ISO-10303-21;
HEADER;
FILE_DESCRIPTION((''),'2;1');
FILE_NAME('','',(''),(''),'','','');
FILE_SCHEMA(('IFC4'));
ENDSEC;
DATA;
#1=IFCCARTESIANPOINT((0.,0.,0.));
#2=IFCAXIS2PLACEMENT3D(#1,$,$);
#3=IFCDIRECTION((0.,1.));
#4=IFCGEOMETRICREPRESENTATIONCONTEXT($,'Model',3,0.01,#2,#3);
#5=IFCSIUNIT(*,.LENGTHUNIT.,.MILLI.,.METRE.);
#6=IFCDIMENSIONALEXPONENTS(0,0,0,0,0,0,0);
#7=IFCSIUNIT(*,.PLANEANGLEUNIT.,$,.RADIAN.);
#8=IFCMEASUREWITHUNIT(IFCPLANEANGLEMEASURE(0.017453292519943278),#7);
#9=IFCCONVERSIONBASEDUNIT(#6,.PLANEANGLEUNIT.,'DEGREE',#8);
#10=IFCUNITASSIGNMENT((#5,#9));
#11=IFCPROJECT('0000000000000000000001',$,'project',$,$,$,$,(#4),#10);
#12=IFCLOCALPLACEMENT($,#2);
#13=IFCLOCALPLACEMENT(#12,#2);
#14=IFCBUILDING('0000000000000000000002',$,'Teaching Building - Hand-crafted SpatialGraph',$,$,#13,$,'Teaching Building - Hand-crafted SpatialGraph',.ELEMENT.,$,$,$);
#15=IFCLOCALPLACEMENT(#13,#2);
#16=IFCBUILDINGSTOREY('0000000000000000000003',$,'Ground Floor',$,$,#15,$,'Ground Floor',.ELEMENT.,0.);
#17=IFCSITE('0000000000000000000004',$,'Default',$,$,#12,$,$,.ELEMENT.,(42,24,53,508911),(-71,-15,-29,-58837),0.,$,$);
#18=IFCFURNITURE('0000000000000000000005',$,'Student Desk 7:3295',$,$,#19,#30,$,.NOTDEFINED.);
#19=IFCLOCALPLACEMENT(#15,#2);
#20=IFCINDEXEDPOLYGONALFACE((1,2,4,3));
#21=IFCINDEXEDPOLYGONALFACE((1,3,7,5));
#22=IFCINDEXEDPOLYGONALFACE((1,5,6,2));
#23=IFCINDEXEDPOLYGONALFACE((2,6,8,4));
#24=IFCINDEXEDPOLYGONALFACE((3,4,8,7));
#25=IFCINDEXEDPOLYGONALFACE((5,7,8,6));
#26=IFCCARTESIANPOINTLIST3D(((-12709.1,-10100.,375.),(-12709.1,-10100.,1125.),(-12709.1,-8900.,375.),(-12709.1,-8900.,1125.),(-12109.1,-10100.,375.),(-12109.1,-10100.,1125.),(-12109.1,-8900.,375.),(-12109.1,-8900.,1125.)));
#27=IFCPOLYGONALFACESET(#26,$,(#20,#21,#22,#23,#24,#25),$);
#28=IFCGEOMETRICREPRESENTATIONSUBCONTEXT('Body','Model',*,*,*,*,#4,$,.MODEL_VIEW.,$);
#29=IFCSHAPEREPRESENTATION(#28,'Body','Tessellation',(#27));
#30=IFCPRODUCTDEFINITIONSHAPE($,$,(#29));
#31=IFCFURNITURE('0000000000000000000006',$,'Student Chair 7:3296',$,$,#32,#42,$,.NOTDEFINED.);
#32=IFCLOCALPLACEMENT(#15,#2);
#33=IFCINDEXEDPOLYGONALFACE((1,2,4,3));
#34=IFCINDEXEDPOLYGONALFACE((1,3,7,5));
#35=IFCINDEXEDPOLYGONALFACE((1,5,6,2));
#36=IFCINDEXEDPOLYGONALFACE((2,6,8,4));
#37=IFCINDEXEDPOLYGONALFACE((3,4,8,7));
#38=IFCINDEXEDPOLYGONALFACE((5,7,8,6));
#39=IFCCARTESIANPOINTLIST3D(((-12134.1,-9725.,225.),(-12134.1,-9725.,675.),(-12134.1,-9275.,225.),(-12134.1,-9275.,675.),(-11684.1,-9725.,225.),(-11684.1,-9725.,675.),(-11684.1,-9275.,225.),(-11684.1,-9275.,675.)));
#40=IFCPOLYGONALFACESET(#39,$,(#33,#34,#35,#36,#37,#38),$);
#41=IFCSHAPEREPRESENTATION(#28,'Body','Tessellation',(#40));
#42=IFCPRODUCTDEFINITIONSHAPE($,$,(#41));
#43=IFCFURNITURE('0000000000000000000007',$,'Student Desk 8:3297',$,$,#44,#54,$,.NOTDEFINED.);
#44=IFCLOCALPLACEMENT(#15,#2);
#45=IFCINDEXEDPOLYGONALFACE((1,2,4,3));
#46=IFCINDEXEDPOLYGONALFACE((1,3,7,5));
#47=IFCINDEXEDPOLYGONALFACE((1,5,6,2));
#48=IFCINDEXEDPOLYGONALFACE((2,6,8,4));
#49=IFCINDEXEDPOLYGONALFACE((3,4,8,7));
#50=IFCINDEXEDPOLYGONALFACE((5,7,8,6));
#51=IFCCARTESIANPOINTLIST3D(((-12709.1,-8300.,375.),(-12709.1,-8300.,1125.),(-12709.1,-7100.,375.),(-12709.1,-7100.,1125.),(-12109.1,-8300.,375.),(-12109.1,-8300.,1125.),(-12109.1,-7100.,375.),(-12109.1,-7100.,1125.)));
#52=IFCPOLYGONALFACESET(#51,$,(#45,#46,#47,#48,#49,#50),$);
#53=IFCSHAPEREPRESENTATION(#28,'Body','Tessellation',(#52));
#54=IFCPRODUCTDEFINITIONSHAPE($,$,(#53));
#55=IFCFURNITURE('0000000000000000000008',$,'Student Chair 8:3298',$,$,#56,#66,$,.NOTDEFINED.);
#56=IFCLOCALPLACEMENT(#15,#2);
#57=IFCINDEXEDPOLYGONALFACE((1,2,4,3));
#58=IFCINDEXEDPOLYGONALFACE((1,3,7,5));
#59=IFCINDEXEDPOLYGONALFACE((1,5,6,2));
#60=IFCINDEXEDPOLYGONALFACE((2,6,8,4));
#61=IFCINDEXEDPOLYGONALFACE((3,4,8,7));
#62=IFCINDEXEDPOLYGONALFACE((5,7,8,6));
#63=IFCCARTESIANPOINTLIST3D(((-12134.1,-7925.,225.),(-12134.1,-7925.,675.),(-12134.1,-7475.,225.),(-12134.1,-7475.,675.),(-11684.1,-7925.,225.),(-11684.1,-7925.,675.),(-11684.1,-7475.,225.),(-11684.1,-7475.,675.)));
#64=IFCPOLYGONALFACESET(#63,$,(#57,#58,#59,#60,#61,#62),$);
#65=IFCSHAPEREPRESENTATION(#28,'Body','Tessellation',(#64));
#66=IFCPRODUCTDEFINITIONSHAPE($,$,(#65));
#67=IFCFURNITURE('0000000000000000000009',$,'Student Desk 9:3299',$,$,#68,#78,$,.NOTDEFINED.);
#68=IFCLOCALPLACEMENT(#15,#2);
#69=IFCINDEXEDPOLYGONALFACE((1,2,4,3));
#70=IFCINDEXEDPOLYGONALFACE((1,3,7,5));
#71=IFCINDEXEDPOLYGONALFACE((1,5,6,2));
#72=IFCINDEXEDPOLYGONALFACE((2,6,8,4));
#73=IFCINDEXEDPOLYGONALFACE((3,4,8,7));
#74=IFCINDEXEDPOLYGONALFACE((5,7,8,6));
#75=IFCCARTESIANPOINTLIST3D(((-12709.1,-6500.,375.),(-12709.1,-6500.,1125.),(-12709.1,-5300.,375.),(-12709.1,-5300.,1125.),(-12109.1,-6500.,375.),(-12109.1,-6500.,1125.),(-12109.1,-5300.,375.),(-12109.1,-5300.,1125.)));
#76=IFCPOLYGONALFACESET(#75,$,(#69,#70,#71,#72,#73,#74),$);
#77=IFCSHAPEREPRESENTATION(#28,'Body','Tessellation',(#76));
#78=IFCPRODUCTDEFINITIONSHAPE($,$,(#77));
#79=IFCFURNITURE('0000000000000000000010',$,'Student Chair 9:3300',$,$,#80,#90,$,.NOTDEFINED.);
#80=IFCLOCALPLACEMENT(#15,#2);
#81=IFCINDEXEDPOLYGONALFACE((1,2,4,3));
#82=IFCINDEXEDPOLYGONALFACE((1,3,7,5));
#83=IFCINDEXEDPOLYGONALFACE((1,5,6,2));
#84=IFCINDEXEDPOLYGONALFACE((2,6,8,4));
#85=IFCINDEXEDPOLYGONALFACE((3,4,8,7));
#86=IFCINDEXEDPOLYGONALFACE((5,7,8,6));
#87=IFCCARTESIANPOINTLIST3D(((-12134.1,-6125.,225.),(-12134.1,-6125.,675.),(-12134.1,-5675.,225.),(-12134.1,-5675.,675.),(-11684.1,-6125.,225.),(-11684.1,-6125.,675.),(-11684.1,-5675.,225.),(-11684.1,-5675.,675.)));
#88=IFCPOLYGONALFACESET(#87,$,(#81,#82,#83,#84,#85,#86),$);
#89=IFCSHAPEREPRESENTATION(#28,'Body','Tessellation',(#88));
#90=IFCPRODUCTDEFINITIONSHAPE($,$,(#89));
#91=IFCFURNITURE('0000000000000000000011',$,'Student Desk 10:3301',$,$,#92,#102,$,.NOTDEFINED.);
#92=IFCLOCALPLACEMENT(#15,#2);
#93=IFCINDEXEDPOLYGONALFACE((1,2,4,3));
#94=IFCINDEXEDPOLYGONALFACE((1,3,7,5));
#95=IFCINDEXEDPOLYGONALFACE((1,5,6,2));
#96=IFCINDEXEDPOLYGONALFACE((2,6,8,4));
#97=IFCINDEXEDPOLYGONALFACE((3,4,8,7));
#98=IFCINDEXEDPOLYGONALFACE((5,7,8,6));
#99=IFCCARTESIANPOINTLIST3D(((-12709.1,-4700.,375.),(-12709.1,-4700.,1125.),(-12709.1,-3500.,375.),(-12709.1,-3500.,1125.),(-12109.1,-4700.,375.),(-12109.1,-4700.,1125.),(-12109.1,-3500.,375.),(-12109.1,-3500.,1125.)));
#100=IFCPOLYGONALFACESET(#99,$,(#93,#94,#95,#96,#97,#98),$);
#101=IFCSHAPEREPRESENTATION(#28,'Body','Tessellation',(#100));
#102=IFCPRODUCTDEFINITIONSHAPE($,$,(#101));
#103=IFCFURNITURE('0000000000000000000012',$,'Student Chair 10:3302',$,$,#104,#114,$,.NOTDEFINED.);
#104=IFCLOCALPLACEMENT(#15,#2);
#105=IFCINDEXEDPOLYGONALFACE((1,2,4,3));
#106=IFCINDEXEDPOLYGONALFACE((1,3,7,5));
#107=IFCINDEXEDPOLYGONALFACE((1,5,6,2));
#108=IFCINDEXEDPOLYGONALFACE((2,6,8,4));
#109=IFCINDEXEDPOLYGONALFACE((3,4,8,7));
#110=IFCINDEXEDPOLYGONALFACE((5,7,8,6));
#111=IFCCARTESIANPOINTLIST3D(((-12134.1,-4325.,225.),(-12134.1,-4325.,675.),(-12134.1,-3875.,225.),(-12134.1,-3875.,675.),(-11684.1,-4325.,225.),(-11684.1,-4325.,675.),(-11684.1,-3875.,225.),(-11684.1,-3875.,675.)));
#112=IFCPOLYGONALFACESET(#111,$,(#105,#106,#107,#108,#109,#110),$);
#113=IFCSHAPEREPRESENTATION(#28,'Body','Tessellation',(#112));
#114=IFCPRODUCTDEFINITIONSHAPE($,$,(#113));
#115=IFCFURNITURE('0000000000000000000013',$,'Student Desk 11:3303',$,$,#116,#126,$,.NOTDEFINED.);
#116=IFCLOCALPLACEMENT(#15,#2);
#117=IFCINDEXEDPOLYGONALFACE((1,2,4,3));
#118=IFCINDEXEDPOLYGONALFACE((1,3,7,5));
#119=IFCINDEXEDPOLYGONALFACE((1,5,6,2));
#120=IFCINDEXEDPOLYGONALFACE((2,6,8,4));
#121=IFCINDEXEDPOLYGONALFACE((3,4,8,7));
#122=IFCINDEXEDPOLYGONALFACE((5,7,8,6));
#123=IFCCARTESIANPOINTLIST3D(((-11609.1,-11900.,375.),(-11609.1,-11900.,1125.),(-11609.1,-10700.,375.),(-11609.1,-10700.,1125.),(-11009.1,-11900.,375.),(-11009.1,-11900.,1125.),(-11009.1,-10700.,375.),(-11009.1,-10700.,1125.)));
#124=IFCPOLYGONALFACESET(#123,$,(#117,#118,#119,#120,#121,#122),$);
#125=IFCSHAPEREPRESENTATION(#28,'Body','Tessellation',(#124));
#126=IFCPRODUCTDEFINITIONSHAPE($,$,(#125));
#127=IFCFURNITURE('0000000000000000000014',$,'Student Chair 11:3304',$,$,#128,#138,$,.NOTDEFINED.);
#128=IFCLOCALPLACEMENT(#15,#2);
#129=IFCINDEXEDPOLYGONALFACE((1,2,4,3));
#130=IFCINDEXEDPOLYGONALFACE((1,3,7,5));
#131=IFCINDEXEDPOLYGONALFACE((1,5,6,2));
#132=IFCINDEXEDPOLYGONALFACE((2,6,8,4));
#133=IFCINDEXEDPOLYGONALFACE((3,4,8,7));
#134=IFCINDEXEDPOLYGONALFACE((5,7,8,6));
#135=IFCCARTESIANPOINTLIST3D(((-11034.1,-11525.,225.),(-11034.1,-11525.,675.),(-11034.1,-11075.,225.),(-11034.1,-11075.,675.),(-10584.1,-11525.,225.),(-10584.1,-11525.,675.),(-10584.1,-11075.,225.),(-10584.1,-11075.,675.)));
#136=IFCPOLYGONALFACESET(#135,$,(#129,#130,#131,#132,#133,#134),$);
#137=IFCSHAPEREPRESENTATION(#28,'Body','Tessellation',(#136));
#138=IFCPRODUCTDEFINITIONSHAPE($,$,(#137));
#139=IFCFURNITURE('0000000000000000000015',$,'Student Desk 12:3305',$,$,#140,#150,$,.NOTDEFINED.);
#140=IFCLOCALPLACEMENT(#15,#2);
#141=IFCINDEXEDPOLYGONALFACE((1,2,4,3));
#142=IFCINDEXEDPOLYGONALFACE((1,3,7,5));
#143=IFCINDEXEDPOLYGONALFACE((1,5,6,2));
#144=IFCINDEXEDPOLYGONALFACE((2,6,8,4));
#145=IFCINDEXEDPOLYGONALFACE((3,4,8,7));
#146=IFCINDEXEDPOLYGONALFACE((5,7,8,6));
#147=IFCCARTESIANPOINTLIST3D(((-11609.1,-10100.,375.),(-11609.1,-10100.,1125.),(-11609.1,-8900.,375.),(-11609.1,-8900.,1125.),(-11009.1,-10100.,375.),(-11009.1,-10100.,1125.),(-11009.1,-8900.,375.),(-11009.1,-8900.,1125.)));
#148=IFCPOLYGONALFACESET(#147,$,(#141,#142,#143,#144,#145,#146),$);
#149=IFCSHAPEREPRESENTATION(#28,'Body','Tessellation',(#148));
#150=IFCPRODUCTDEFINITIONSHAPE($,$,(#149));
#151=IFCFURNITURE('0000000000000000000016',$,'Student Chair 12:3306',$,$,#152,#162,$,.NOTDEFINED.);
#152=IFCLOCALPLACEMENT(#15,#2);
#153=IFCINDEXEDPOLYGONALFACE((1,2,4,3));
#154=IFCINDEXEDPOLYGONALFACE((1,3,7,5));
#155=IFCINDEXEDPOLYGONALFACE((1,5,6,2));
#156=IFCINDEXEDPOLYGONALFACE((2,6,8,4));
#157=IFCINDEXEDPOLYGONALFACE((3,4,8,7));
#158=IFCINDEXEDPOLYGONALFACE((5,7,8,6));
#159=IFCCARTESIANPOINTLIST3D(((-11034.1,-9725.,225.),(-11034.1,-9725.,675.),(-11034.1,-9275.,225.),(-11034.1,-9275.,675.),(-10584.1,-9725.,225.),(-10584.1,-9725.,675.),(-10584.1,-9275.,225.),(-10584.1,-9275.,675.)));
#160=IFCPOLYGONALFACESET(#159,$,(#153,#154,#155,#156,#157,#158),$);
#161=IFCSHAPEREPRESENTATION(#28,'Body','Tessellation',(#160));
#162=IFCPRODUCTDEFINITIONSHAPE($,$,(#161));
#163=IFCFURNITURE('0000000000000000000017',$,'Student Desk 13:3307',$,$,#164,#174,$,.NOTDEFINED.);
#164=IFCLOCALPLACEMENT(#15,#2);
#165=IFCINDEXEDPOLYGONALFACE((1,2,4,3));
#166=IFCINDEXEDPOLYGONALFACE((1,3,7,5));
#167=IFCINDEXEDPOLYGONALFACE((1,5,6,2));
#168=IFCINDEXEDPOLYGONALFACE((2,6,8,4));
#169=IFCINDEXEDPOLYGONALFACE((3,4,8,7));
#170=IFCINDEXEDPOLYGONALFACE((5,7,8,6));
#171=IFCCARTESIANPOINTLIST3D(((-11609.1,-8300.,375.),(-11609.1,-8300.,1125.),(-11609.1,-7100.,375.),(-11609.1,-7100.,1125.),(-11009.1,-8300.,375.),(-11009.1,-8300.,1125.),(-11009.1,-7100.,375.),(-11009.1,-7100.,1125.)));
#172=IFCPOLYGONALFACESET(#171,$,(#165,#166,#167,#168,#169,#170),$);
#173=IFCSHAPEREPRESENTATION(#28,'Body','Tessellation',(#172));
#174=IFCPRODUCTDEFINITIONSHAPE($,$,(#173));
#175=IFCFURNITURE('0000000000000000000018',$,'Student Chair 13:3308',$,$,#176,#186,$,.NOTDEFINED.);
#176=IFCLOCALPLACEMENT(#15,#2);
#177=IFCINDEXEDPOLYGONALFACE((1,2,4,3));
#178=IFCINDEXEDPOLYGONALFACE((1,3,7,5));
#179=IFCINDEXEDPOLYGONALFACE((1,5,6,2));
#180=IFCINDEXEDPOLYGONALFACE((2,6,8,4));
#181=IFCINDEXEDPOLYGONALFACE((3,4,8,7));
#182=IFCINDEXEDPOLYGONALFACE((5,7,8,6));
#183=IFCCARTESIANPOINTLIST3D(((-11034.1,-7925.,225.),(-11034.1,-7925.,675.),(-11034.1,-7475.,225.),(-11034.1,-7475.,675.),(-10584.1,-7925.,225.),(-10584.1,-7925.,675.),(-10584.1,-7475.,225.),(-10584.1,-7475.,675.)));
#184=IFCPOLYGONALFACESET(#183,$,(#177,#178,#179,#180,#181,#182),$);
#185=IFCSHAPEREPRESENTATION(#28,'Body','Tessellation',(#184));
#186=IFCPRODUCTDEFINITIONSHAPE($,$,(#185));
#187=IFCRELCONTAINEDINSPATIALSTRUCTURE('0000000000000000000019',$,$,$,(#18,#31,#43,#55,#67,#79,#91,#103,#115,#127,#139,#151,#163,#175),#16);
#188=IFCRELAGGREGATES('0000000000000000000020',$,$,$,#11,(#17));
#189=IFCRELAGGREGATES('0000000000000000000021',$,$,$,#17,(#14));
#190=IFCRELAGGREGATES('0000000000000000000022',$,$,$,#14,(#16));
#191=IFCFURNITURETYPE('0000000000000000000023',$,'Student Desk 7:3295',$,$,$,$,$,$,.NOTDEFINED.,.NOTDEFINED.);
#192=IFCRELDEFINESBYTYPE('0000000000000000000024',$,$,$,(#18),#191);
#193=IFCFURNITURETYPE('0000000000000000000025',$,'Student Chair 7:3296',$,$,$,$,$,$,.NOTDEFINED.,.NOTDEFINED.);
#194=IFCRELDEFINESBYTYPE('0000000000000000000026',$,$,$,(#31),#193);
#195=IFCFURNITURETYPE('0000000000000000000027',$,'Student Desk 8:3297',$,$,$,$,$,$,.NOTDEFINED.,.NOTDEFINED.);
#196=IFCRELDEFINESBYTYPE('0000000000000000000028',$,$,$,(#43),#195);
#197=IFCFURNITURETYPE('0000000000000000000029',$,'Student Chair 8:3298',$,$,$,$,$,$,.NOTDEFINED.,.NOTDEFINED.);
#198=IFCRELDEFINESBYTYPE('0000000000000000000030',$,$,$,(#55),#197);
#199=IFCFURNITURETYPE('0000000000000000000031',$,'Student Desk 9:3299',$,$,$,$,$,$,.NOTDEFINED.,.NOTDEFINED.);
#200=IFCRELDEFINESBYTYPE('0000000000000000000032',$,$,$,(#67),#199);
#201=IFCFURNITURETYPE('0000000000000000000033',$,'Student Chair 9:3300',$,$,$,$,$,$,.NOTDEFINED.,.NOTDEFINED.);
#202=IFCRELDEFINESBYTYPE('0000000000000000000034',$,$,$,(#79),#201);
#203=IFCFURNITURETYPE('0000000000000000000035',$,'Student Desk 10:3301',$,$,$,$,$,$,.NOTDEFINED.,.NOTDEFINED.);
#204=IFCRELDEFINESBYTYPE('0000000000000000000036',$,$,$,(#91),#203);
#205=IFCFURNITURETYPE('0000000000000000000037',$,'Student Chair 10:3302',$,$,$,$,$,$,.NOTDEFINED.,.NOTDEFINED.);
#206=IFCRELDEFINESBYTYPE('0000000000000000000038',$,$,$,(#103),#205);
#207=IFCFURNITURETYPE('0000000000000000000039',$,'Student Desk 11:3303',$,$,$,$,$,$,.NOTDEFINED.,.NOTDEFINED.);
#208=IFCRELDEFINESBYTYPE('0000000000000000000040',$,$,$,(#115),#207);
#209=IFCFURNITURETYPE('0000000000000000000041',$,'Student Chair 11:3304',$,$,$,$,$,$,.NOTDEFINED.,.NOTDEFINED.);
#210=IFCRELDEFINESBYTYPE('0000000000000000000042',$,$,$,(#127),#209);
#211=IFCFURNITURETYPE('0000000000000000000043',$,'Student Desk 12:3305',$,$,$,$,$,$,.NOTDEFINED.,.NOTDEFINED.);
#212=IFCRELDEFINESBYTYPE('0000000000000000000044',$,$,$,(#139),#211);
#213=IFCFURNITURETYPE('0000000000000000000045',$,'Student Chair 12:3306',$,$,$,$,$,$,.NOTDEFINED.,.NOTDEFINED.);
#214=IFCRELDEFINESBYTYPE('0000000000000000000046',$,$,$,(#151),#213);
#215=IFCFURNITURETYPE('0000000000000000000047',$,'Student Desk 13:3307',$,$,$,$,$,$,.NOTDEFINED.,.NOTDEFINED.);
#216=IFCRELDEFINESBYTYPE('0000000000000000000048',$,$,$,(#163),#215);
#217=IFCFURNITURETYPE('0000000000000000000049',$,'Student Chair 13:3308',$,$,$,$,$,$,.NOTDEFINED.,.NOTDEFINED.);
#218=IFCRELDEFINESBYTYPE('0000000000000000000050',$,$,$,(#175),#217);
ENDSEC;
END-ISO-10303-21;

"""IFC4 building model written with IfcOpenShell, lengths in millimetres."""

from ifc_helpers import new_model, entity, si_unit, converted_unit, direction, frame, frame_2d, origin, origin_2d_with_axis, place, context, subcontext, project, spatial, rectangle, extrude, type_object, element, save


model = new_model("IFC4")

# Units and contexts
model_context = context("Model", 3, precision=0.01, world=origin(), true_north=direction((0.0, 1.0)))
body_context = subcontext(model_context, "Body", "Model", "MODEL_VIEW")
ifc_project = project(units=[si_unit("LENGTHUNIT", "METRE", prefix="MILLI"), converted_unit("PLANEANGLEUNIT", "DEGREE", entity("IfcPlaneAngleMeasure", 0.017453292519943278), si_unit("PLANEANGLEUNIT", "RADIAN"), dimensions=[0, 0, 0, 0, 0, 0, 0])], contexts=[model_context])

# Site, building, storey
site_placement = place(None, origin())
site = spatial("IfcSite", under=ifc_project, at=site_placement, Name="Default", CompositionType="ELEMENT", RefLatitude=(42, 24, 53, 508911), RefLongitude=(-71, -15, -29, -58837), RefElevation=0.0)
building_placement = place(site_placement, origin())
building = spatial("IfcBuilding", under=site, at=building_placement, Name="Teaching Building - Hand-crafted SpatialGraph", LongName="Teaching Building - Hand-crafted SpatialGraph", CompositionType="ELEMENT")
storey_placement = place(building_placement, origin())
storey = spatial("IfcBuildingStorey", under=building, at=storey_placement, Name="Ground Floor", LongName="Ground Floor", CompositionType="ELEMENT", Elevation=0.0)

# Furniture
furniture_type_1 = type_object("IfcFurnitureType", Name="Student Desk 7:3295", PredefinedType="NOTDEFINED")
furniture_1_placement = place(storey_placement, origin())
element("IfcFurniture", 1, at=furniture_1_placement, inside=storey, type_object=furniture_type_1, Name="Student Desk 7:3295", PredefinedType="NOTDEFINED", context=body_context, shape_type="SweptSolid", body=[
    extrude(rectangle(XDim=1200.0, YDim=600.0, at=origin_2d_with_axis()), frame((-12409.1, -9500.0, 375.0), z_axis=(0.0, 0.0, 1.0), x_axis=(0.0, 1.0, 0.0)), (0.0, 0.0, 1.0), 750.0),
])
furniture_type_2 = type_object("IfcFurnitureType", Name="Student Chair 7:3296", PredefinedType="NOTDEFINED")
furniture_2_placement = place(storey_placement, origin())
element("IfcFurniture", 2, at=furniture_2_placement, inside=storey, type_object=furniture_type_2, Name="Student Chair 7:3296", PredefinedType="NOTDEFINED", context=body_context, shape_type="SweptSolid", body=[
    extrude(rectangle(XDim=450.0, YDim=450.0, at=origin_2d_with_axis()), frame((-11909.1, -9500.0, 225.0)), (0.0, 0.0, 1.0), 450.0),
])
furniture_type_3 = type_object("IfcFurnitureType", Name="Student Desk 8:3297", PredefinedType="NOTDEFINED")
furniture_3_placement = place(storey_placement, origin())
element("IfcFurniture", 3, at=furniture_3_placement, inside=storey, type_object=furniture_type_3, Name="Student Desk 8:3297", PredefinedType="NOTDEFINED", context=body_context, shape_type="SweptSolid", body=[
    extrude(rectangle(XDim=1200.0, YDim=600.0, at=origin_2d_with_axis()), frame((-12409.1, -7700.0, 375.0), z_axis=(0.0, 0.0, 1.0), x_axis=(0.0, 1.0, 0.0)), (0.0, 0.0, 1.0), 750.0),
])
furniture_type_4 = type_object("IfcFurnitureType", Name="Student Chair 8:3298", PredefinedType="NOTDEFINED")
furniture_4_placement = place(storey_placement, origin())
element("IfcFurniture", 4, at=furniture_4_placement, inside=storey, type_object=furniture_type_4, Name="Student Chair 8:3298", PredefinedType="NOTDEFINED", context=body_context, shape_type="SweptSolid", body=[
    extrude(rectangle(XDim=450.0, YDim=450.0, at=frame_2d((0.0, 0.0), x_axis=(1.0, 0.0))), frame((-11909.1, -7700.0, 225.0)), (0.0, 0.0, 1.0), 450.0),
])
furniture_type_5 = type_object("IfcFurnitureType", Name="Student Desk 9:3299", PredefinedType="NOTDEFINED")
furniture_5_placement = place(storey_placement, origin())
element("IfcFurniture", 5, at=furniture_5_placement, inside=storey, type_object=furniture_type_5, Name="Student Desk 9:3299", PredefinedType="NOTDEFINED", context=body_context, shape_type="SweptSolid", body=[
    extrude(rectangle(XDim=1200.0, YDim=600.0, at=origin_2d_with_axis()), frame((-12409.1, -5900.0, 375.0), z_axis=(0.0, 0.0, 1.0), x_axis=(0.0, 1.0, 0.0)), (0.0, 0.0, 1.0), 750.0),
])
furniture_type_6 = type_object("IfcFurnitureType", Name="Student Chair 9:3300", PredefinedType="NOTDEFINED")
furniture_6_placement = place(storey_placement, origin())
element("IfcFurniture", 6, at=furniture_6_placement, inside=storey, type_object=furniture_type_6, Name="Student Chair 9:3300", PredefinedType="NOTDEFINED", context=body_context, shape_type="SweptSolid", body=[
    extrude(rectangle(XDim=450.0, YDim=450.0, at=origin_2d_with_axis()), frame((-11909.1, -5900.0, 225.0)), (0.0, 0.0, 1.0), 450.0),
])
furniture_type_7 = type_object("IfcFurnitureType", Name="Student Desk 10:3301", PredefinedType="NOTDEFINED")
furniture_7_placement = place(storey_placement, origin())
element("IfcFurniture", 7, at=furniture_7_placement, inside=storey, type_object=furniture_type_7, Name="Student Desk 10:3301", PredefinedType="NOTDEFINED", context=body_context, shape_type="SweptSolid", body=[
    extrude(rectangle(XDim=1200.0, YDim=600.0, at=origin_2d_with_axis()), frame((-12409.1, -4100.0, 375.0), z_axis=(0.0, 0.0, 1.0), x_axis=(0.0, 1.0, 0.0)), (0.0, 0.0, 1.0), 750.0),
])
furniture_type_8 = type_object("IfcFurnitureType", Name="Student Chair 10:3302", PredefinedType="NOTDEFINED")
furniture_8_placement = place(storey_placement, origin())
element("IfcFurniture", 8, at=furniture_8_placement, inside=storey, type_object=furniture_type_8, Name="Student Chair 10:3302", PredefinedType="NOTDEFINED", context=body_context, shape_type="SweptSolid", body=[
    extrude(rectangle(XDim=450.0, YDim=450.0, at=origin_2d_with_axis()), frame((-11909.1, -4100.0, 225.0)), (0.0, 0.0, 1.0), 450.0),
])
furniture_type_9 = type_object("IfcFurnitureType", Name="Student Desk 11:3303", PredefinedType="NOTDEFINED")
furniture_9_placement = place(storey_placement, origin())
element("IfcFurniture", 9, at=furniture_9_placement, inside=storey, type_object=furniture_type_9, Name="Student Desk 11:3303", PredefinedType="NOTDEFINED", context=body_context, shape_type="SweptSolid", body=[
    extrude(rectangle(XDim=1200.0, YDim=600.0, at=origin_2d_with_axis()), frame((-11309.1, -11300.0, 375.0), z_axis=(0.0, 0.0, 1.0), x_axis=(0.0, 1.0, 0.0)), (0.0, 0.0, 1.0), 750.0),
])
furniture_type_10 = type_object("IfcFurnitureType", Name="Student Chair 11:3304", PredefinedType="NOTDEFINED")
furniture_10_placement = place(storey_placement, origin())
element("IfcFurniture", 10, at=furniture_10_placement, inside=storey, type_object=furniture_type_10, Name="Student Chair 11:3304", PredefinedType="NOTDEFINED", context=body_context, shape_type="SweptSolid", body=[
    extrude(rectangle(XDim=450.0, YDim=450.0, at=origin_2d_with_axis()), frame((-10809.1, -11300.0, 225.0)), (0.0, 0.0, 1.0), 450.0),
])
furniture_type_11 = type_object("IfcFurnitureType", Name="Student Desk 12:3305", PredefinedType="NOTDEFINED")
furniture_11_placement = place(storey_placement, origin())
element("IfcFurniture", 11, at=furniture_11_placement, inside=storey, type_object=furniture_type_11, Name="Student Desk 12:3305", PredefinedType="NOTDEFINED", context=body_context, shape_type="SweptSolid", body=[
    extrude(rectangle(XDim=1200.0, YDim=600.0, at=origin_2d_with_axis()), frame((-11309.1, -9500.0, 375.0), z_axis=(0.0, 0.0, 1.0), x_axis=(0.0, 1.0, 0.0)), (0.0, 0.0, 1.0), 750.0),
])
furniture_type_12 = type_object("IfcFurnitureType", Name="Student Chair 12:3306", PredefinedType="NOTDEFINED")
furniture_12_placement = place(storey_placement, origin())
element("IfcFurniture", 12, at=furniture_12_placement, inside=storey, type_object=furniture_type_12, Name="Student Chair 12:3306", PredefinedType="NOTDEFINED", context=body_context, shape_type="SweptSolid", body=[
    extrude(rectangle(XDim=450.0, YDim=450.0, at=origin_2d_with_axis()), frame((-10809.1, -9500.0, 225.0)), (0.0, 0.0, 1.0), 450.0),
])
furniture_type_13 = type_object("IfcFurnitureType", Name="Student Desk 13:3307", PredefinedType="NOTDEFINED")
furniture_13_placement = place(storey_placement, origin())
element("IfcFurniture", 13, at=furniture_13_placement, inside=storey, type_object=furniture_type_13, Name="Student Desk 13:3307", PredefinedType="NOTDEFINED", context=body_context, shape_type="SweptSolid", body=[
    extrude(rectangle(XDim=1200.0, YDim=600.0, at=origin_2d_with_axis()), frame((-11309.1, -7700.0, 375.0), z_axis=(0.0, 0.0, 1.0), x_axis=(0.0, 1.0, 0.0)), (0.0, 0.0, 1.0), 750.0),
])
furniture_type_14 = type_object("IfcFurnitureType", Name="Student Chair 13:3308", PredefinedType="NOTDEFINED")
furniture_14_placement = place(storey_placement, origin())
element("IfcFurniture", 14, at=furniture_14_placement, inside=storey, type_object=furniture_type_14, Name="Student Chair 13:3308", PredefinedType="NOTDEFINED", context=body_context, shape_type="SweptSolid", body=[
    extrude(rectangle(XDim=450.0, YDim=450.0, at=frame_2d((0.0, 0.0), x_axis=(1.0, 0.0))), frame((-10809.1, -7700.0, 225.0)), (0.0, 0.0, 1.0), 450.0),
])

save(model, "model.ifc")
